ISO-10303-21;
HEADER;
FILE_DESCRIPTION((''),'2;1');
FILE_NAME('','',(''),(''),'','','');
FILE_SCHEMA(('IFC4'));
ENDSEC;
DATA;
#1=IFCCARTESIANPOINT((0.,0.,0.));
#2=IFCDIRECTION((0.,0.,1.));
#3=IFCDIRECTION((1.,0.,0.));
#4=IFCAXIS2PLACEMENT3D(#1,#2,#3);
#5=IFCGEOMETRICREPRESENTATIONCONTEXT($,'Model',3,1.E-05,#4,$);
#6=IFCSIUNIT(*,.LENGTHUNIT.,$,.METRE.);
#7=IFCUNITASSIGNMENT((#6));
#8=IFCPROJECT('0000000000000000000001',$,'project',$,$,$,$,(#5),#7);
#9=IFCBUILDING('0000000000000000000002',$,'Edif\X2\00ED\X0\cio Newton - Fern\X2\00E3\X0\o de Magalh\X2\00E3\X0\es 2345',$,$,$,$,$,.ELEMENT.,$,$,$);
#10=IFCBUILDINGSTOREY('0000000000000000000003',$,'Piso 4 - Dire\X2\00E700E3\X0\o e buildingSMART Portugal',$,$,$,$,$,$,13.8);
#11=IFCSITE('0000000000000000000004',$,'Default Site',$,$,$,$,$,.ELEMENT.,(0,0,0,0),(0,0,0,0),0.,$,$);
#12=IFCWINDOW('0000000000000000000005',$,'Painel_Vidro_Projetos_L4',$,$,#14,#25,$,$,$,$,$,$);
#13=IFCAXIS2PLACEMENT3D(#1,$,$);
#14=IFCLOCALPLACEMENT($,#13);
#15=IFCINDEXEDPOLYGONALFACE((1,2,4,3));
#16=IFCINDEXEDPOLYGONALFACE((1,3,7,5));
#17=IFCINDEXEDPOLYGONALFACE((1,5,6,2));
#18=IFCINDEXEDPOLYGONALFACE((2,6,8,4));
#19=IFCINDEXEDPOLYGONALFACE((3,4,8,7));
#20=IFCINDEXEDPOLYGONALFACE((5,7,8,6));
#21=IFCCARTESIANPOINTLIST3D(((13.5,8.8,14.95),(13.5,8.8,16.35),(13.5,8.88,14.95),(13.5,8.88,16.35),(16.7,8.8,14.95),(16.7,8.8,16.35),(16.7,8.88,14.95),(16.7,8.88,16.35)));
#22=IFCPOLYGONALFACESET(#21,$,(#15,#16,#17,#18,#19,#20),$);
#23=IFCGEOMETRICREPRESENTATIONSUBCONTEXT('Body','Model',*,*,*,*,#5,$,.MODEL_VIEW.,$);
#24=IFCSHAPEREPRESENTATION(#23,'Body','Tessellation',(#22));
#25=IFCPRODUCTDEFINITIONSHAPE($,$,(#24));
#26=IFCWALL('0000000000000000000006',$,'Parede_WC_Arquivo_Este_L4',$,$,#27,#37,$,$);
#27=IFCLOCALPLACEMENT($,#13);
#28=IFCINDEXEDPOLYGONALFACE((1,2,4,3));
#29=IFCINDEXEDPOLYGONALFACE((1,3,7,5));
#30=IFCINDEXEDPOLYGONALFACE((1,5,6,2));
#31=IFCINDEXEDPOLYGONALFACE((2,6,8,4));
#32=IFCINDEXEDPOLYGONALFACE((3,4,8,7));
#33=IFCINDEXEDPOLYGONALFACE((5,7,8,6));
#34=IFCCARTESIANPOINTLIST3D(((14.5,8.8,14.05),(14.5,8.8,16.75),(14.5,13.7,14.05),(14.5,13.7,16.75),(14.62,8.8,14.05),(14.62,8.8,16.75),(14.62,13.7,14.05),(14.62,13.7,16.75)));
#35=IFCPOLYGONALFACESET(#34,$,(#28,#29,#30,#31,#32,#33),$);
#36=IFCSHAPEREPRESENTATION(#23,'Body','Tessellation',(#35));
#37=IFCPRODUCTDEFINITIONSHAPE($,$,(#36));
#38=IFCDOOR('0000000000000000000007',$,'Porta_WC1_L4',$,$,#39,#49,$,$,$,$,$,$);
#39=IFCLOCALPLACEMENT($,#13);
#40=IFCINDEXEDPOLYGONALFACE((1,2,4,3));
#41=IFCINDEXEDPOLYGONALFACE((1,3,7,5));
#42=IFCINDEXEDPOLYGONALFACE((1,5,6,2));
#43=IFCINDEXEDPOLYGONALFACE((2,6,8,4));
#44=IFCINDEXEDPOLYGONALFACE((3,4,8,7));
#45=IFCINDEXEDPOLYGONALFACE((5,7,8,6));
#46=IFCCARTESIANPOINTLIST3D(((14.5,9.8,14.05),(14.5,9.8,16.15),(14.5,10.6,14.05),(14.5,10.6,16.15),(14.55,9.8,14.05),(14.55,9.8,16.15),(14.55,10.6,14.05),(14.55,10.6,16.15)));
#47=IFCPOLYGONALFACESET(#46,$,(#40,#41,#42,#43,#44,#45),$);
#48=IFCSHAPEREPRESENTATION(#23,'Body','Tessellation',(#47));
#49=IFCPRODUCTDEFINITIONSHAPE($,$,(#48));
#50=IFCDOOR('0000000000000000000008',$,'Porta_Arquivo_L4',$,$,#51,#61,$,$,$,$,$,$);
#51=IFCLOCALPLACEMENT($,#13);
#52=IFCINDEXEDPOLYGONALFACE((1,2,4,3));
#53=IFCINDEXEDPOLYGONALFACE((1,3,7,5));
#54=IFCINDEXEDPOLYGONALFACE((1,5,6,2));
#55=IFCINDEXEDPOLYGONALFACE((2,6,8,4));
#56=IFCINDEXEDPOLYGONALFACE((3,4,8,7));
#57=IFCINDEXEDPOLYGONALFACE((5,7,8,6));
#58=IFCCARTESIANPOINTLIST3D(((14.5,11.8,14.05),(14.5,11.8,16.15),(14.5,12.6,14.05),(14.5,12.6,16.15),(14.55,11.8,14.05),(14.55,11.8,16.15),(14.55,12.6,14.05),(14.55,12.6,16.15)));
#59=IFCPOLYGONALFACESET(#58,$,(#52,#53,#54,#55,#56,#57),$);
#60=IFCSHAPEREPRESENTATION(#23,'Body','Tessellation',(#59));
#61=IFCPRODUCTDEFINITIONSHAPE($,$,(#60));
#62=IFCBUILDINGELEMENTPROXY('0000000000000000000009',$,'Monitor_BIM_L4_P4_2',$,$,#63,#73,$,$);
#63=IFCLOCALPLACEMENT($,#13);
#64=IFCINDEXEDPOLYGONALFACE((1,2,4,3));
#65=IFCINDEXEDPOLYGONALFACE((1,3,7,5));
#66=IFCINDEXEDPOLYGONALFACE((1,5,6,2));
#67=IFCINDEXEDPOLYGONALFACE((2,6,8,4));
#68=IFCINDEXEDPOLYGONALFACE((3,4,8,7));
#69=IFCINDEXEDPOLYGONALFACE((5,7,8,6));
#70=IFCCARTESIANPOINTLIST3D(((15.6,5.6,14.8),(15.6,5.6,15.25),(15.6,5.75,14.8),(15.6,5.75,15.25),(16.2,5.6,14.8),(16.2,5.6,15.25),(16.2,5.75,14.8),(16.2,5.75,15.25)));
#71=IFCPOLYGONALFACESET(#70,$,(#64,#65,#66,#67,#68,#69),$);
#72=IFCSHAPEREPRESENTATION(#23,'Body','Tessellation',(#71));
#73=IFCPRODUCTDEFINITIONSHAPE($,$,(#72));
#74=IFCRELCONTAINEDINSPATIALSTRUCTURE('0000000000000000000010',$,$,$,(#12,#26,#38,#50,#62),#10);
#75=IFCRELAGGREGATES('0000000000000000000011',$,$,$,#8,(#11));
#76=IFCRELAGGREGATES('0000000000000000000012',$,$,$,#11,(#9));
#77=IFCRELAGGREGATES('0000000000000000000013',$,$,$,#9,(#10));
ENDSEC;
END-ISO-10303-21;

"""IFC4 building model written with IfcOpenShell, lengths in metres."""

from ifc_helpers import new_model, si_unit, frame, frame_2d, origin_with_axes, place, context, subcontext, project, spatial, rectangle, extrude, element, save


model = new_model("IFC4")

# Units and contexts
model_context = context("Model", 3, precision=1e-05, world=origin_with_axes())
body_context = subcontext(model_context, "Body", "Model", "MODEL_VIEW")
ifc_project = project(units=[si_unit("LENGTHUNIT", "METRE")], contexts=[model_context])

# Site, building, storey
site = spatial("IfcSite", under=ifc_project, Name="Default Site", CompositionType="ELEMENT", RefLatitude=(0, 0, 0, 0), RefLongitude=(0, 0, 0, 0), RefElevation=0.0)
building = spatial("IfcBuilding", under=site, Name="Edifício Newton - Fernão de Magalhães 2345", CompositionType="ELEMENT")
storey = spatial("IfcBuildingStorey", under=building, Name="Piso 4 - Direção e buildingSMART Portugal", Elevation=13.8)

# Window
window_1_placement = place(None, frame((13.5, 8.8, 14.95), z_axis=(0.0, 0.0, 1.0), x_axis=(1.0, 0.0, 0.0)))
element("IfcWindow", 1, at=window_1_placement, inside=storey, Name="Painel_Vidro_Projetos_L4", context=body_context, shape_type="SweptSolid", body=[
    extrude(rectangle(XDim=3.2, YDim=0.08, at=frame_2d((1.6, 0.04))), origin_with_axes(), (0.0, 0.0, 1.0), 1.4),
])

# Wall
wall_1_placement = place(None, frame((14.5, 8.8, 14.05), z_axis=(0.0, 0.0, 1.0), x_axis=(1.0, 0.0, 0.0)))
element("IfcWall", 2, at=wall_1_placement, inside=storey, Name="Parede_WC_Arquivo_Este_L4", context=body_context, shape_type="SweptSolid", body=[
    extrude(rectangle(XDim=0.12, YDim=4.9, at=frame_2d((0.06, 2.45))), origin_with_axes(), (0.0, 0.0, 1.0), 2.7),
])

# Doors
for number, where, z_axis, x_axis, name in (
    (3, (14.5, 9.8, 14.05), (0.0, 0.0, 1.0), (1.0, 0.0, 0.0), "Porta_WC1_L4"),
    (4, (14.5, 11.8, 14.05), (0.0, 0.0, 1.0), (1.0, 0.0, 0.0), "Porta_Arquivo_L4"),
):
    element("IfcDoor", number, at=place(None, frame(where, z_axis=z_axis, x_axis=x_axis)), inside=storey, Name=name, context=body_context, shape_type="SweptSolid", body=[
        extrude(rectangle(XDim=0.05, YDim=0.8, at=frame_2d((0.025, 0.4))), origin_with_axes(), (0.0, 0.0, 1.0), 2.1),
    ])

# Building element proxy
proxy_placement = place(None, frame((15.6, 5.6, 14.8), z_axis=(0.0, 0.0, 1.0), x_axis=(1.0, 0.0, 0.0)))
element("IfcBuildingElementProxy", 5, at=proxy_placement, inside=storey, Name="Monitor_BIM_L4_P4_2", context=body_context, shape_type="SweptSolid", body=[
    extrude(rectangle(XDim=0.6, YDim=0.15, at=frame_2d((0.3, 0.075))), origin_with_axes(), (0.0, 0.0, 1.0), 0.45),
])

save(model, "model.ifc")
